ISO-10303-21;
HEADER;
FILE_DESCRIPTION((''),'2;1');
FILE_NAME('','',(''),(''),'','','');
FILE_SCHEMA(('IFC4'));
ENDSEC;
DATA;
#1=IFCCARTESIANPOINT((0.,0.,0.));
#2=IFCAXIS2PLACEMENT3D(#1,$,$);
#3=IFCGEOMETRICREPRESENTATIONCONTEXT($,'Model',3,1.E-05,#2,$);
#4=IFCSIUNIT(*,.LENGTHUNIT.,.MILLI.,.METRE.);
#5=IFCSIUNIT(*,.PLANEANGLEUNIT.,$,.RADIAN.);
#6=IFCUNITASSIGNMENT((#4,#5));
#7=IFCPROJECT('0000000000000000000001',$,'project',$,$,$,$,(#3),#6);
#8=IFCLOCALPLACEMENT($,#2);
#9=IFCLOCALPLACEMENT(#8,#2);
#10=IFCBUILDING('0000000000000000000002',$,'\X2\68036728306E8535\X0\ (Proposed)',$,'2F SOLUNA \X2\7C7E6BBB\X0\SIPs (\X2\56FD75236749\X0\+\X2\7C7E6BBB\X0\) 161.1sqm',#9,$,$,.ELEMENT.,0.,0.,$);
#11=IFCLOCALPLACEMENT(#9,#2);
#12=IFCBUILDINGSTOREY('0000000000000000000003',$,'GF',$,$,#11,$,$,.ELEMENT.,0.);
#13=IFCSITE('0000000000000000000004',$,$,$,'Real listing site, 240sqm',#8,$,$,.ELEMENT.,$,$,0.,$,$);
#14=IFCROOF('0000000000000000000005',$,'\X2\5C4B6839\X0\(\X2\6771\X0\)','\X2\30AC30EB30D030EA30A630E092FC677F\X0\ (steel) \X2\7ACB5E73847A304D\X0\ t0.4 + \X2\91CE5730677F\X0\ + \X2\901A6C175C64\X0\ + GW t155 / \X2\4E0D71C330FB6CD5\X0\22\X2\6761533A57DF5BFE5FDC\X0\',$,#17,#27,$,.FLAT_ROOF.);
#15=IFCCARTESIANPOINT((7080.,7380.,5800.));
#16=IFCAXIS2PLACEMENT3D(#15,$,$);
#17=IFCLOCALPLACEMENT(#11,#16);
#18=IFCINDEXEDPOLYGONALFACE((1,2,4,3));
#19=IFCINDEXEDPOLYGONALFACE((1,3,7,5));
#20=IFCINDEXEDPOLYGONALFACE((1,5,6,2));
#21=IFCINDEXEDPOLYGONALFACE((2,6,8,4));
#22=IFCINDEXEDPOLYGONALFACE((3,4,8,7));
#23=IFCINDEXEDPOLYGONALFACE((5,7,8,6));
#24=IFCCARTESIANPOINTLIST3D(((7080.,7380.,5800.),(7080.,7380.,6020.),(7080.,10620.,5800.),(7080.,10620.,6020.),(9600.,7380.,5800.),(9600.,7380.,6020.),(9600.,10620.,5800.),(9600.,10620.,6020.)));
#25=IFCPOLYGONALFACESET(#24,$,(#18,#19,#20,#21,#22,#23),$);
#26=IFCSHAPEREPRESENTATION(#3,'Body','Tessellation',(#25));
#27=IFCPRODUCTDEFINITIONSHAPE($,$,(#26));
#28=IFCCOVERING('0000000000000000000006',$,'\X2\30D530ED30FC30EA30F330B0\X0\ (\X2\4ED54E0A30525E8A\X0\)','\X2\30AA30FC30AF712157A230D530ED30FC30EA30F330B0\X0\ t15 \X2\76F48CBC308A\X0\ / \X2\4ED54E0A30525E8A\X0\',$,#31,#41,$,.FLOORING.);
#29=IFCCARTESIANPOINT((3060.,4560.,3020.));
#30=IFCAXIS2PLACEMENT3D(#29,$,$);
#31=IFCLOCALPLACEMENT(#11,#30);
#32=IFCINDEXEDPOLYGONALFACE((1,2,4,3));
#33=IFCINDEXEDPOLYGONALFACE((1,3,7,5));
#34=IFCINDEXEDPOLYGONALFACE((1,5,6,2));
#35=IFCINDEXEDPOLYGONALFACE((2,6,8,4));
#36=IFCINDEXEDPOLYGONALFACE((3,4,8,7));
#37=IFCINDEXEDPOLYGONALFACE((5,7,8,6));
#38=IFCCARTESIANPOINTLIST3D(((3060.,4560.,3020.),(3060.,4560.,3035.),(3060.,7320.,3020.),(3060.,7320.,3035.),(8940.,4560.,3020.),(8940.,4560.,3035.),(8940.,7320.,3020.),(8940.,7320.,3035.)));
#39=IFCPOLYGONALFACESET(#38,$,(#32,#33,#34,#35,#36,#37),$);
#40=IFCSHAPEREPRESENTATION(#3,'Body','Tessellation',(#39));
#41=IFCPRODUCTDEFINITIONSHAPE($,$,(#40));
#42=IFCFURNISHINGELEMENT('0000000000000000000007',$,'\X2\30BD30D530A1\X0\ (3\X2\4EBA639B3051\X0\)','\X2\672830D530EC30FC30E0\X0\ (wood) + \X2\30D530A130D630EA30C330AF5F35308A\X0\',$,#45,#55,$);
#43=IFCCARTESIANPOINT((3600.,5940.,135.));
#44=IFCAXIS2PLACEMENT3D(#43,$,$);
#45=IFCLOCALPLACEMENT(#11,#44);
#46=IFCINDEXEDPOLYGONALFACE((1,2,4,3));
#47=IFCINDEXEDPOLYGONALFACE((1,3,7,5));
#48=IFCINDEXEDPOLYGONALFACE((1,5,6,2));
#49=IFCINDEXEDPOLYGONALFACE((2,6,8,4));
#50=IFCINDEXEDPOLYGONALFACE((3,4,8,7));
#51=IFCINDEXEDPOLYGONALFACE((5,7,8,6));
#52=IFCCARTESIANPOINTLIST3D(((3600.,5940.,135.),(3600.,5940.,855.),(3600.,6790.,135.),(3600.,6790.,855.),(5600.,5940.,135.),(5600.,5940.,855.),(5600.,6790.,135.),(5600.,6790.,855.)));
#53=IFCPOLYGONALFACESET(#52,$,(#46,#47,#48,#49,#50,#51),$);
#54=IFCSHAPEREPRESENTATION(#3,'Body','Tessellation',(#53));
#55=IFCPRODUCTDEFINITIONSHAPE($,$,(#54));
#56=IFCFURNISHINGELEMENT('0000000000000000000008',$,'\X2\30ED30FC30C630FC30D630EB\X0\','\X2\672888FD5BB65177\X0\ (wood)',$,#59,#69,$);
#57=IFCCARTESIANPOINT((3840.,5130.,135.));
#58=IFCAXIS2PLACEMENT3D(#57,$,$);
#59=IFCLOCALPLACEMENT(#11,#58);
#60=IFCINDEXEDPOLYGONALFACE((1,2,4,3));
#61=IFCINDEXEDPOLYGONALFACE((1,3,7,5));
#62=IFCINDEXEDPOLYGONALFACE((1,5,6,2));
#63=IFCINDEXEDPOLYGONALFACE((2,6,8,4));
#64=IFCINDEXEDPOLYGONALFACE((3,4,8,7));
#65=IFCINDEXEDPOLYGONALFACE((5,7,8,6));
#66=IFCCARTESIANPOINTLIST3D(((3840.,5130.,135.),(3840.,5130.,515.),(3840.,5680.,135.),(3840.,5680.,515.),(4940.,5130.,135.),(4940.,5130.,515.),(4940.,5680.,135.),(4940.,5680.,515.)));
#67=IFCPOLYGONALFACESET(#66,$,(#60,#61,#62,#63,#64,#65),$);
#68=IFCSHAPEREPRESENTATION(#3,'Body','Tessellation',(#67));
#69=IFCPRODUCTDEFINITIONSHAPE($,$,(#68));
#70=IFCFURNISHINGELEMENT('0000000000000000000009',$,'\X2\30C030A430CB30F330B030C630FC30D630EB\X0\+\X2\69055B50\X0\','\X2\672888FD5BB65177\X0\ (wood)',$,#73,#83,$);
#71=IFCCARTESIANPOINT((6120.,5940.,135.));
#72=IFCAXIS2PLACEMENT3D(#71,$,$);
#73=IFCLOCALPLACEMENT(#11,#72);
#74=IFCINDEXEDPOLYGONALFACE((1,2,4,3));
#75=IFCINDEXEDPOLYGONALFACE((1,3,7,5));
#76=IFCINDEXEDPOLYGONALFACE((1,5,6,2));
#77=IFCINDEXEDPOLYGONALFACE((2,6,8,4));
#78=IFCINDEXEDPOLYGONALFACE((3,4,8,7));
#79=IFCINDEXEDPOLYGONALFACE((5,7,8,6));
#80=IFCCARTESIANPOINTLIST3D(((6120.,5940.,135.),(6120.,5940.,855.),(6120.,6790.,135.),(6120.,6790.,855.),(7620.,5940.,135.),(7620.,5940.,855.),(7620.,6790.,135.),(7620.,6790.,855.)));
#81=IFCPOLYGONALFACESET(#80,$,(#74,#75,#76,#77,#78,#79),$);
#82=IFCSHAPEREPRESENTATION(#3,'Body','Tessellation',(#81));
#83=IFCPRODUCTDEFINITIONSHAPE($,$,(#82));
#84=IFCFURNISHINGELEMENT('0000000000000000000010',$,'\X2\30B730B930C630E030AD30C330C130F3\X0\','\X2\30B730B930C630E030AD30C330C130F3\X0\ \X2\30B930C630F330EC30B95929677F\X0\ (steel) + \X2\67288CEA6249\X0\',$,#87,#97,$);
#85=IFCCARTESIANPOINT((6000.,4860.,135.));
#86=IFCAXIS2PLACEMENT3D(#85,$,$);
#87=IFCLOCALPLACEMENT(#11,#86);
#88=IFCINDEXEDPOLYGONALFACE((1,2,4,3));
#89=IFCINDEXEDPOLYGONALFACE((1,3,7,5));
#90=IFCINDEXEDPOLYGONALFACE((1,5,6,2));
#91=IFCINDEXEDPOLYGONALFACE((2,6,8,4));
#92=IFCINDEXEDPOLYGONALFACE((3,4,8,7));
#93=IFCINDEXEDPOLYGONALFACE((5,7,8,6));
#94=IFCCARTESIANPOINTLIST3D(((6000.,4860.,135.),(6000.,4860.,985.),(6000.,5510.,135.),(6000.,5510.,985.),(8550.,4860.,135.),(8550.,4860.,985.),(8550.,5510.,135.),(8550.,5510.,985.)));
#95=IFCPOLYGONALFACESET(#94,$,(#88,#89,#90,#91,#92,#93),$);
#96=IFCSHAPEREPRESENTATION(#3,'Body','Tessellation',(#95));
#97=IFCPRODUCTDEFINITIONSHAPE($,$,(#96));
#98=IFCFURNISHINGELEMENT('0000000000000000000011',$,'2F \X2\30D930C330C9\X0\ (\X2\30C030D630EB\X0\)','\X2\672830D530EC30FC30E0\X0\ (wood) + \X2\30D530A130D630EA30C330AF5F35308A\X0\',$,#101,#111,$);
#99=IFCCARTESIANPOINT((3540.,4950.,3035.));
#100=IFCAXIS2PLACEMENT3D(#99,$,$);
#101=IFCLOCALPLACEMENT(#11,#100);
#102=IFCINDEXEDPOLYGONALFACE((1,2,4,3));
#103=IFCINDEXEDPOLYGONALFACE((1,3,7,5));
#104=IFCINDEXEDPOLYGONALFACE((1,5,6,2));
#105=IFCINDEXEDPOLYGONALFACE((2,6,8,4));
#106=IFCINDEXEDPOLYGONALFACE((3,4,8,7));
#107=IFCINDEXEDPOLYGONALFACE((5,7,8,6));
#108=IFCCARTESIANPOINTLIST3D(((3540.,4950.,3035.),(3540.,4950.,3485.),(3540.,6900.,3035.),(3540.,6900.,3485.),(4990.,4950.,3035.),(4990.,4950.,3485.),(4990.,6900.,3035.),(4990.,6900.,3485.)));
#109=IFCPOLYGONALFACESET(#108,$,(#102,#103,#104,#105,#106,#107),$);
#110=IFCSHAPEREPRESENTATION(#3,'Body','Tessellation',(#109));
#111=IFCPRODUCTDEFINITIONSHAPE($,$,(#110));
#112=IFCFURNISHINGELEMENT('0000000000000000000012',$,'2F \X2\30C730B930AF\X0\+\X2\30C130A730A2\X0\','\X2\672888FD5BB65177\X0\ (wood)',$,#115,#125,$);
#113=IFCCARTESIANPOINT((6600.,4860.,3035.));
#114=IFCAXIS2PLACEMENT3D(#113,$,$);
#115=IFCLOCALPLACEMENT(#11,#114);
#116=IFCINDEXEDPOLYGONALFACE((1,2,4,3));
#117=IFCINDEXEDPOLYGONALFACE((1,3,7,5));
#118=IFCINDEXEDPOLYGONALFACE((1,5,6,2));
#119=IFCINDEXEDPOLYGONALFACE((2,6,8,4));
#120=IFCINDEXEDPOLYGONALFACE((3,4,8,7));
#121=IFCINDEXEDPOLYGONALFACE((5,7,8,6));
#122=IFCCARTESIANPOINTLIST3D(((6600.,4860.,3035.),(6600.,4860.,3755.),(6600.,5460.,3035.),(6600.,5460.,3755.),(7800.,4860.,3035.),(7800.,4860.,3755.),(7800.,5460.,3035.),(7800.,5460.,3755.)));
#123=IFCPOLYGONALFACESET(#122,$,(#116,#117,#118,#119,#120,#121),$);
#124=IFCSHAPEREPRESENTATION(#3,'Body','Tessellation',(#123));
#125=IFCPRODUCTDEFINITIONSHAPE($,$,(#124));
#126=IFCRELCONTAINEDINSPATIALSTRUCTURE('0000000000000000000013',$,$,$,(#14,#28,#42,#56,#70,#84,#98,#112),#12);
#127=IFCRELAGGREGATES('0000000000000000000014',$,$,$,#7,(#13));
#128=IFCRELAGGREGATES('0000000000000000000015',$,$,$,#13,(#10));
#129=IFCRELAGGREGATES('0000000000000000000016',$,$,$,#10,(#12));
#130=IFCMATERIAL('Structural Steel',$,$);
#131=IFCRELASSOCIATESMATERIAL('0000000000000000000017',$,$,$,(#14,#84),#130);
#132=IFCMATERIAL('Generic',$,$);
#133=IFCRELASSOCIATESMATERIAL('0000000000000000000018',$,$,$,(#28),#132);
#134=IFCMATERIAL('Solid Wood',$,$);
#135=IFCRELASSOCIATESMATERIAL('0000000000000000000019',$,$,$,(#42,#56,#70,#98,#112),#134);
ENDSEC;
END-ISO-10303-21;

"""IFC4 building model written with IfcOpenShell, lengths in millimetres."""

from ifc_helpers import new_model, si_unit, frame, frame_2d, origin, place, context, project, spatial, rectangle, extrude, material, element, save


model = new_model("IFC4")

# Units and contexts
model_context = context("Model", 3, precision=1e-05, world=origin())
ifc_project = project(units=[si_unit("LENGTHUNIT", "METRE", prefix="MILLI"), si_unit("PLANEANGLEUNIT", "RADIAN")], contexts=[model_context])

# Site, building, storey
site_placement = place(None, origin())
site = spatial("IfcSite", under=ifc_project, at=site_placement, ObjectType="Real listing site, 240sqm", CompositionType="ELEMENT", RefElevation=0.0)
building_placement = place(site_placement, origin())
building = spatial("IfcBuilding", under=site, at=building_placement, Name="栃木の蔵 (Proposed)", ObjectType="2F SOLUNA 籾殻SIPs (国産杉+籾殻) 161.1sqm", CompositionType="ELEMENT", ElevationOfRefHeight=0.0, ElevationOfTerrain=0.0)
storey_placement = place(building_placement, origin())
storey = spatial("IfcBuildingStorey", under=building, at=storey_placement, Name="GF", CompositionType="ELEMENT", Elevation=0.0)

# Shared definitions
ifc_material_1 = material(Name="Solid Wood")

# Shared definitions
ifc_material_2 = material(Name="Generic")

# Roof
ifc_material_3 = material(Name="Structural Steel")
roof_placement = place(storey_placement, frame((7080.0, 7380.0, 5800.0)))
element("IfcRoof", 1, at=roof_placement, inside=storey, material=ifc_material_3, Name="屋根(東)", Description="ガルバリウム鋼板 (steel) 立平葺き t0.4 + 野地板 + 通気層 + GW t155 / 不燃・法22条区域対応", PredefinedType="FLAT_ROOF", context=model_context, shape_type="SweptSolid", body=[
    extrude(rectangle(XDim=2520.0, YDim=3240.0, at=frame_2d((1260.0, 1620.0))), frame((7080.0, 7380.0, 5800.0)), (0.0, 0.0, 1.0), 220.0),
])

# Covering
covering_placement = place(storey_placement, frame((3060.0, 4560.0, 3020.0)))
element("IfcCovering", 2, at=covering_placement, inside=storey, material=ifc_material_2, Name="フローリング (仕上げ床)", Description="オーク無垢フローリング t15 直貼り / 仕上げ床", PredefinedType="FLOORING", context=model_context, shape_type="SweptSolid", body=[
    extrude(rectangle(XDim=5880.0, YDim=2760.0, at=frame_2d((2940.0, 1380.0))), frame((3060.0, 4560.0, 3020.0)), (0.0, 0.0, 1.0), 15.0),
])

# Furnishing elements
furnishing_1_placement = place(storey_placement, frame((3600.0, 5940.0, 135.0)))
element("IfcFurnishingElement", 3, at=furnishing_1_placement, inside=storey, material=ifc_material_1, Name="ソファ (3人掛け)", Description="木フレーム (wood) + ファブリック張り", context=model_context, shape_type="SweptSolid", body=[
    extrude(rectangle(XDim=2000.0, YDim=850.0, at=frame_2d((1000.0, 425.0))), frame((3600.0, 5940.0, 135.0)), (0.0, 0.0, 1.0), 720.0),
])
furnishing_2_placement = place(storey_placement, frame((3840.0, 5130.0, 135.0)))
element("IfcFurnishingElement", 4, at=furnishing_2_placement, inside=storey, material=ifc_material_1, Name="ローテーブル", Description="木製家具 (wood)", context=model_context, shape_type="SweptSolid", body=[
    extrude(rectangle(XDim=1100.0, YDim=550.0, at=frame_2d((550.0, 275.0))), frame((3840.0, 5130.0, 135.0)), (0.0, 0.0, 1.0), 380.0),
])
furnishing_3_placement = place(storey_placement, frame((6120.0, 5940.0, 135.0)))
element("IfcFurnishingElement", 5, at=furnishing_3_placement, inside=storey, material=ifc_material_1, Name="ダイニングテーブル+椅子", Description="木製家具 (wood)", context=model_context, shape_type="SweptSolid", body=[
    extrude(rectangle(XDim=1500.0, YDim=850.0, at=frame_2d((750.0, 425.0))), frame((6120.0, 5940.0, 135.0)), (0.0, 0.0, 1.0), 720.0),
])
furnishing_4_placement = place(storey_placement, frame((6000.0, 4860.0, 135.0)))
element("IfcFurnishingElement", 6, at=furnishing_4_placement, inside=storey, material=ifc_material_3, Name="システムキッチン", Description="システムキッチン ステンレス天板 (steel) + 木質扉", context=model_context, shape_type="SweptSolid", body=[
    extrude(rectangle(XDim=2550.0, YDim=650.0, at=frame_2d((1275.0, 325.0))), frame((6000.0, 4860.0, 135.0)), (0.0, 0.0, 1.0), 850.0),
])
furnishing_5_placement = place(storey_placement, frame((3540.0, 4950.0, 3035.0)))
element("IfcFurnishingElement", 7, at=furnishing_5_placement, inside=storey, material=ifc_material_1, Name="2F ベッド (ダブル)", Description="木フレーム (wood) + ファブリック張り", context=model_context, shape_type="SweptSolid", body=[
    extrude(rectangle(XDim=1450.0, YDim=1950.0, at=frame_2d((725.0, 975.0))), frame((3540.0, 4950.0, 3035.0)), (0.0, 0.0, 1.0), 450.0),
])
furnishing_6_placement = place(storey_placement, frame((6600.0, 4860.0, 3035.0)))
element("IfcFurnishingElement", 8, at=furnishing_6_placement, inside=storey, material=ifc_material_1, Name="2F デスク+チェア", Description="木製家具 (wood)", context=model_context, shape_type="SweptSolid", body=[
    extrude(rectangle(XDim=1200.0, YDim=600.0, at=frame_2d((600.0, 300.0))), frame((6600.0, 4860.0, 3035.0)), (0.0, 0.0, 1.0), 720.0),
])

save(model, "model.ifc")
